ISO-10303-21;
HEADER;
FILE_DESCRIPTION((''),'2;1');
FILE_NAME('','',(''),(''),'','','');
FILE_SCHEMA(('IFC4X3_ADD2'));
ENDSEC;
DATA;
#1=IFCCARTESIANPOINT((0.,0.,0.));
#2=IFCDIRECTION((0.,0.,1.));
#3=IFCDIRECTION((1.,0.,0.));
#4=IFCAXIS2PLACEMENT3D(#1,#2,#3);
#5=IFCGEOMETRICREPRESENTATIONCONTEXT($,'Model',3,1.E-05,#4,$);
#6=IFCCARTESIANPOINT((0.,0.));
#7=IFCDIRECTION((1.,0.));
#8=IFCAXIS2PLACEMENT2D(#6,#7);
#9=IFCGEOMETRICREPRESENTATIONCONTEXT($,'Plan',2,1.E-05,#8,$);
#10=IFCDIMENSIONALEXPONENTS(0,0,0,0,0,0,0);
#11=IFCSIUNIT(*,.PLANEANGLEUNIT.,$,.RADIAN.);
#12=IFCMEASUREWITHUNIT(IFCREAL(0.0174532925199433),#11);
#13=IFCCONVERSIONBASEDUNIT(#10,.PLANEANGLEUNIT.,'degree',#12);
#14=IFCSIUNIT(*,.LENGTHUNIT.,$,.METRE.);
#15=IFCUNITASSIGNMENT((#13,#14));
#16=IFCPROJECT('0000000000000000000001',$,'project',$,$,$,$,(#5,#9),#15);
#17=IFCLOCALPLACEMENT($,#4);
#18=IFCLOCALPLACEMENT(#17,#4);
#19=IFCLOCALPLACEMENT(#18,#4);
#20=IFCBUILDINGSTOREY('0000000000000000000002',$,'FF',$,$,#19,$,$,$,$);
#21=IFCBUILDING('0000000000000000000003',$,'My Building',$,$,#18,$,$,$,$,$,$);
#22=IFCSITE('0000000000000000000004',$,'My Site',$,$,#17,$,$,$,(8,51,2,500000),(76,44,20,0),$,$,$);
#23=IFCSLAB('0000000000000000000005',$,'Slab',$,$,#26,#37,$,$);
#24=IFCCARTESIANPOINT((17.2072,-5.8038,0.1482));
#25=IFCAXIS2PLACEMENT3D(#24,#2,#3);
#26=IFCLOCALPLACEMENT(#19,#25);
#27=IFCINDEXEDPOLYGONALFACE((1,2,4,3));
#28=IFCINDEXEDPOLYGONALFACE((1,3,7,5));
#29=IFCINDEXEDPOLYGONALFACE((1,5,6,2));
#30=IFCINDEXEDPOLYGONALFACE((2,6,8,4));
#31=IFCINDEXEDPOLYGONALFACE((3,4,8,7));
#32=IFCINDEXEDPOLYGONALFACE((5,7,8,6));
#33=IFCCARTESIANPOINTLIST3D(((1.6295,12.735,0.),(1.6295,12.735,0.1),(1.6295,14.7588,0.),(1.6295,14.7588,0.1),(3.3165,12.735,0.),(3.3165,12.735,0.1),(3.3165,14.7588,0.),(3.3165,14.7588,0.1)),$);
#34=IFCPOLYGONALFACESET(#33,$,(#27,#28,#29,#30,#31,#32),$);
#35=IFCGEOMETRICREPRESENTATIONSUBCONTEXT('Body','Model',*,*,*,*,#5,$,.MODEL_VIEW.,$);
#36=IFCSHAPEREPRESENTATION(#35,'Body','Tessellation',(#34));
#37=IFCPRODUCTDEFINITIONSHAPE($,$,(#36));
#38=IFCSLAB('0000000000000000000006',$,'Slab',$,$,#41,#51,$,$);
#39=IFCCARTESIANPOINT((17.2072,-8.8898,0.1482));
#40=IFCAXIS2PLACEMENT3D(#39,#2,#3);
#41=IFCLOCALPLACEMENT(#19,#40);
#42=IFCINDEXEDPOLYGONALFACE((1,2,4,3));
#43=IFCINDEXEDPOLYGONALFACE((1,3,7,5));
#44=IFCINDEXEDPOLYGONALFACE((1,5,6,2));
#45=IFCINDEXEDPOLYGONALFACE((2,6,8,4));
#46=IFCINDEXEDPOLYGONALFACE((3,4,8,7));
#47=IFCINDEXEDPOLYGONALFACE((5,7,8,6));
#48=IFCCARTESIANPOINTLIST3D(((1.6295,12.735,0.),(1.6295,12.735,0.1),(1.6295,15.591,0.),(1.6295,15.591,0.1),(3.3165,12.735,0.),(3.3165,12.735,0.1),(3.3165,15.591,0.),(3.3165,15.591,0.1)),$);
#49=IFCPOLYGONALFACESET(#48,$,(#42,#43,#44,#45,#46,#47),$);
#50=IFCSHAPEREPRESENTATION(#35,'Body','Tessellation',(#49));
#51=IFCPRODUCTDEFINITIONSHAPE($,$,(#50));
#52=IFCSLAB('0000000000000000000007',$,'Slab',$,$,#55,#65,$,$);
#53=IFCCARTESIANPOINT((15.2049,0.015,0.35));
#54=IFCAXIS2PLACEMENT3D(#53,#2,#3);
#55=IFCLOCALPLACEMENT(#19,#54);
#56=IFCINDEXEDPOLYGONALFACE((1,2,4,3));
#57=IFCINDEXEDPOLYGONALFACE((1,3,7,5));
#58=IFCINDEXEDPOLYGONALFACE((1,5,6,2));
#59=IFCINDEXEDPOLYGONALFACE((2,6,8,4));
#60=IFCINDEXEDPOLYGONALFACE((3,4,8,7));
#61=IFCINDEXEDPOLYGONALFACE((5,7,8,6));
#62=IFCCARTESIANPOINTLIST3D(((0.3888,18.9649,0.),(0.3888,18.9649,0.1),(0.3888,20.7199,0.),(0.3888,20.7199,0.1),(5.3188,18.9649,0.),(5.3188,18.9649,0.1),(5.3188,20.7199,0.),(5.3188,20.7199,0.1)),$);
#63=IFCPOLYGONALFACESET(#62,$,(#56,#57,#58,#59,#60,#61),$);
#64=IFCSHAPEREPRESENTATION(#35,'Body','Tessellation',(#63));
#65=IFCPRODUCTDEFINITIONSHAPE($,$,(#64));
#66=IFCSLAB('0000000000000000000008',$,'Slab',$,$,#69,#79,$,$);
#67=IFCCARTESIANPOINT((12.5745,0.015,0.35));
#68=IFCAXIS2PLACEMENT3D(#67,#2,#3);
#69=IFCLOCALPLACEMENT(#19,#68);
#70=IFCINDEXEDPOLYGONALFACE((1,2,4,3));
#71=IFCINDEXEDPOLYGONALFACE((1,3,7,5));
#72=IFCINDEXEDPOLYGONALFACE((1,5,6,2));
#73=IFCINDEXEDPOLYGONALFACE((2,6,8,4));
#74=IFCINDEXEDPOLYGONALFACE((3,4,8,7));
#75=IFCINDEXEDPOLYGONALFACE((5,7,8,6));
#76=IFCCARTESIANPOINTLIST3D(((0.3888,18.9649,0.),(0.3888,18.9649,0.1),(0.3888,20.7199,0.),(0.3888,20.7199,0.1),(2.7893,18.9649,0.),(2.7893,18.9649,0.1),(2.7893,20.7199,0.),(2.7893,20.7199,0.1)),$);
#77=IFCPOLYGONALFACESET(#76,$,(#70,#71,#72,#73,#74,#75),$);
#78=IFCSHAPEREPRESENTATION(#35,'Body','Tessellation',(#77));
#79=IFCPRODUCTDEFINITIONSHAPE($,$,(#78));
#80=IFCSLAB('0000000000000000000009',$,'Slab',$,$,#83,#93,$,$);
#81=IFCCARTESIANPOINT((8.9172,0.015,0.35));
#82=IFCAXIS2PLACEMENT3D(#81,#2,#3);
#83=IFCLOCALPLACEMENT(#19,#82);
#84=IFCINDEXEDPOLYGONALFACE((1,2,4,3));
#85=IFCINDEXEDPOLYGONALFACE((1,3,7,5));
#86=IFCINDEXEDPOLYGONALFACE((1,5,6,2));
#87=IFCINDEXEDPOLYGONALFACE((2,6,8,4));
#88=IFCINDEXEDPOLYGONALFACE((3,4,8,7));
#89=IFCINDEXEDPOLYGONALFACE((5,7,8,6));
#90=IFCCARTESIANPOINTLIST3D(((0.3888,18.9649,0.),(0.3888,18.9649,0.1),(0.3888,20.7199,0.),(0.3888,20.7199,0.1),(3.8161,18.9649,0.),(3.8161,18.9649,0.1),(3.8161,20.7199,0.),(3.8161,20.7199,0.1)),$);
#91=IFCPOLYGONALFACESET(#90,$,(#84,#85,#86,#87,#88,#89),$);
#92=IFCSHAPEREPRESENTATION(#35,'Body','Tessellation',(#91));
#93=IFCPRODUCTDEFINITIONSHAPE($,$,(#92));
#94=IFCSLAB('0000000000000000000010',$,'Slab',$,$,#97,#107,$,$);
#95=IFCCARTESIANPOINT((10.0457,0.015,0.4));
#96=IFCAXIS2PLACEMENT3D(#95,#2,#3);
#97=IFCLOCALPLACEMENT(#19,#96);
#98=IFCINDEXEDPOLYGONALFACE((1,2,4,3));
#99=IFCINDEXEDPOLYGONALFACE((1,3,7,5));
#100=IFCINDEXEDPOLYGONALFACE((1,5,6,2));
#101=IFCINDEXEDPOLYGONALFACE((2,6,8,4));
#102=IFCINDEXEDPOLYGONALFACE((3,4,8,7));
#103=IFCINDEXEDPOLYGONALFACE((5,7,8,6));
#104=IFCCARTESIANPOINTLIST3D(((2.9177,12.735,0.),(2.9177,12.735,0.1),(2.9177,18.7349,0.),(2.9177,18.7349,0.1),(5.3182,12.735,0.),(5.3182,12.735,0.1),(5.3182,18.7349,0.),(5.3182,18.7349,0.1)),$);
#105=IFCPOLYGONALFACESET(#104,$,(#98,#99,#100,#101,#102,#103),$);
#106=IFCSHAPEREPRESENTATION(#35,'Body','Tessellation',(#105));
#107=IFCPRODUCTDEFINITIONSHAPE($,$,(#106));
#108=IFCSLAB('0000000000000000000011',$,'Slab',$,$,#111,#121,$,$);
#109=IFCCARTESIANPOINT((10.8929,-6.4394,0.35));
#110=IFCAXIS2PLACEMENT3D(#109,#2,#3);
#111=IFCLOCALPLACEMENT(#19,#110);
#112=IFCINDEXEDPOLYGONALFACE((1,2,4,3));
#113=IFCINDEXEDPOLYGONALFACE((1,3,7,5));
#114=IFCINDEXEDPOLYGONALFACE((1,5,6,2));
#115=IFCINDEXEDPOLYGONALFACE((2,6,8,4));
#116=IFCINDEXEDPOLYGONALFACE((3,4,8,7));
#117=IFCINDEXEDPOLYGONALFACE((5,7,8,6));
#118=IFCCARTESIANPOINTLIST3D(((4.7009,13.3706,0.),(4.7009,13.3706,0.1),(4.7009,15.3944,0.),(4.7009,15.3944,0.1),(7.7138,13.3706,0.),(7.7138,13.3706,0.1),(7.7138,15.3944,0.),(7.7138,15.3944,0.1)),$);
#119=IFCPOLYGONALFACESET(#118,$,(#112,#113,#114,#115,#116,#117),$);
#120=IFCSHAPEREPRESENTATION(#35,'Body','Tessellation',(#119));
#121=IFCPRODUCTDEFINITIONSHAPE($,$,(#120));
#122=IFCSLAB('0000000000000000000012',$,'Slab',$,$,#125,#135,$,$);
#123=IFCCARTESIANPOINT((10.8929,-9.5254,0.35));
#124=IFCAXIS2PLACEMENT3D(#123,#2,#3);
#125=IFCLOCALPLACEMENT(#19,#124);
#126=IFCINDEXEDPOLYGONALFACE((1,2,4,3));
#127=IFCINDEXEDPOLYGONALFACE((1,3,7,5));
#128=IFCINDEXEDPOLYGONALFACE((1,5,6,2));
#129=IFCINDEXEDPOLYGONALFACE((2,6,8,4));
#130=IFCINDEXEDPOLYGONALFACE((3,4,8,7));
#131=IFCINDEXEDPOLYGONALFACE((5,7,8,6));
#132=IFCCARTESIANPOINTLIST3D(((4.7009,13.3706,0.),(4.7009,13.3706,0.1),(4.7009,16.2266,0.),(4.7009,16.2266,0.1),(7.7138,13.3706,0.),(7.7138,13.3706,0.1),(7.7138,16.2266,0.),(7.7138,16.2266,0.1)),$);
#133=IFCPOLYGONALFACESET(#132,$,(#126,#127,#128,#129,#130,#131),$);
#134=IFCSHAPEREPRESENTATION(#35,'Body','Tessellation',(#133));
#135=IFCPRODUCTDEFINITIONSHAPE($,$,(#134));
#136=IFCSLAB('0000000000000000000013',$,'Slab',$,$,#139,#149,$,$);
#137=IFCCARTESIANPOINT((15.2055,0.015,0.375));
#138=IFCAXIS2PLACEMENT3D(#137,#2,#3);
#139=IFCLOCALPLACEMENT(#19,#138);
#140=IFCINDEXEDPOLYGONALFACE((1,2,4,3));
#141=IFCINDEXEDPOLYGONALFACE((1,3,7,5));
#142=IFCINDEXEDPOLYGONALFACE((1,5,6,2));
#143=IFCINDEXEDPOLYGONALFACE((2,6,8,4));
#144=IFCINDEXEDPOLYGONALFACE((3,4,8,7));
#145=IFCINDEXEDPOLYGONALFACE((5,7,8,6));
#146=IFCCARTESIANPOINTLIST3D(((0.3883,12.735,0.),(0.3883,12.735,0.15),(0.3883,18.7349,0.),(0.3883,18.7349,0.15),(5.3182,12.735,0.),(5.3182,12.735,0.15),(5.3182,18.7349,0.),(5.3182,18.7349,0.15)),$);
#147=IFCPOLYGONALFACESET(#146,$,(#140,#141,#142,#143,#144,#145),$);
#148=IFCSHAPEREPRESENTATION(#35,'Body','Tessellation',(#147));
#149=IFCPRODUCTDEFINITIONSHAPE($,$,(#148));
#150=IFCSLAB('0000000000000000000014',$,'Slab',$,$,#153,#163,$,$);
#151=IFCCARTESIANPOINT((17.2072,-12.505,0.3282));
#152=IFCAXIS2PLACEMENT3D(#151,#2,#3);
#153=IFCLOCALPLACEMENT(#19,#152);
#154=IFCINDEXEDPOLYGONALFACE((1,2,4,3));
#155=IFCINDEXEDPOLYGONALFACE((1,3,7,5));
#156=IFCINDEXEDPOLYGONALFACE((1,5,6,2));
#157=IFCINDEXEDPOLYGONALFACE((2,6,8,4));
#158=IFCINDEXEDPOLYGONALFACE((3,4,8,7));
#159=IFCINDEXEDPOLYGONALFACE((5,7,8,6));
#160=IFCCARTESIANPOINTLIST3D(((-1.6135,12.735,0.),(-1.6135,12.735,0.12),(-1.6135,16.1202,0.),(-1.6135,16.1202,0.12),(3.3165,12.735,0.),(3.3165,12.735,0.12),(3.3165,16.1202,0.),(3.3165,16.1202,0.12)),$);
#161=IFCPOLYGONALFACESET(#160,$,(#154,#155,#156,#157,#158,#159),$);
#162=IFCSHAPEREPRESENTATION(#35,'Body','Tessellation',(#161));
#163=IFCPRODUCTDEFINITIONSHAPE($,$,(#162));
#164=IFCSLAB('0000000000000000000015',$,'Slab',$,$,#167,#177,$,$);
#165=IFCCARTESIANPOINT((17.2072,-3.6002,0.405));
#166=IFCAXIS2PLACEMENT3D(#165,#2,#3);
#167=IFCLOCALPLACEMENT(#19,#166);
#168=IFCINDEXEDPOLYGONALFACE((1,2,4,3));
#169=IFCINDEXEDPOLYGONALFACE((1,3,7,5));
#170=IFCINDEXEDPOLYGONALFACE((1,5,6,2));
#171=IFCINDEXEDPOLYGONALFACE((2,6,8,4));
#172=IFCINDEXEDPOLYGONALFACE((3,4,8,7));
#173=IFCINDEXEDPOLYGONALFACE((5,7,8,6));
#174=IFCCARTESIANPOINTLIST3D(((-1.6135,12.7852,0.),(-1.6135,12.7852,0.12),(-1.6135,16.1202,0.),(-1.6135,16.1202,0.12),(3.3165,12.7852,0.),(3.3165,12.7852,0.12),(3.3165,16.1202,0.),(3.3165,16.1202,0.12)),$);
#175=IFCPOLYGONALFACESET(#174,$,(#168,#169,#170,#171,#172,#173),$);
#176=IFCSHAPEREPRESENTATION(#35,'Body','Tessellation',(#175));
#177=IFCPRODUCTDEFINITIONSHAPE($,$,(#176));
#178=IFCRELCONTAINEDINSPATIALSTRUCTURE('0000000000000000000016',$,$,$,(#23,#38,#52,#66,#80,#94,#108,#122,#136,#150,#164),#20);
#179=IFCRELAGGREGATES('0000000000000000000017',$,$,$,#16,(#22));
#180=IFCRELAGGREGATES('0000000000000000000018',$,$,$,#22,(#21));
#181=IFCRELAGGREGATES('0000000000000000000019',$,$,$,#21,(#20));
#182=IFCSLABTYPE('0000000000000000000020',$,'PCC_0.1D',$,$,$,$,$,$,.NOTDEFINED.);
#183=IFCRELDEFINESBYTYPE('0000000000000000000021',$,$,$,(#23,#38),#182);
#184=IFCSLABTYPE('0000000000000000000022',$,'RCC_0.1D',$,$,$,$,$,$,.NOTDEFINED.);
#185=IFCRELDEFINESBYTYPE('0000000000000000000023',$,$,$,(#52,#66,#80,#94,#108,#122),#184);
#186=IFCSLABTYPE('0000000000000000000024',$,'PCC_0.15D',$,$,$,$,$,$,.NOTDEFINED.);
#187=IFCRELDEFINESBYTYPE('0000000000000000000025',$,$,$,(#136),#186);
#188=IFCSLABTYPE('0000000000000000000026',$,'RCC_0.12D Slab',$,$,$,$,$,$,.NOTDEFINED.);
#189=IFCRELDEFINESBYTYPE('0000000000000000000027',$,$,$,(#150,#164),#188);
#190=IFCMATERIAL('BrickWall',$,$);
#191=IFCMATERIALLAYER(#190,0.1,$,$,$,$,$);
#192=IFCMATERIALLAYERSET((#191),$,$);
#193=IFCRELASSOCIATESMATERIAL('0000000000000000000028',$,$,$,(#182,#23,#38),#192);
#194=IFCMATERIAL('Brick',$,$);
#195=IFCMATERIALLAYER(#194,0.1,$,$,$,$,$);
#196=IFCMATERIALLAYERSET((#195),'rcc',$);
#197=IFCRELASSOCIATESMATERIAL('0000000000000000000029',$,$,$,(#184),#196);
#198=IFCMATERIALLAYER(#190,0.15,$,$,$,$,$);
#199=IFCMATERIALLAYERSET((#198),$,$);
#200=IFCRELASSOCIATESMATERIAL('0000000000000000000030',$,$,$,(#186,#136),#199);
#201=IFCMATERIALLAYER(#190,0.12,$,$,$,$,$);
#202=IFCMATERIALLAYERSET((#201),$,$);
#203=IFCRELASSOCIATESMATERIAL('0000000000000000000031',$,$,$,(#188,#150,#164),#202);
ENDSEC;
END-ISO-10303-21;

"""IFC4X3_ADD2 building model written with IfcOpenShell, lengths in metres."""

from ifc_helpers import new_model, entity, si_unit, converted_unit, frame, origin_with_axes, origin_2d_with_axis, place, context, subcontext, project, spatial, indexed_curve, outline, extrude, material, layer, layer_set, layer_usage, type_object, element, save


model = new_model("IFC4X3_ADD2")

# Units and contexts
model_context = context("Model", 3, precision=1e-05, world=origin_with_axes())
plan_context = context("Plan", 2, precision=1e-05, world=origin_2d_with_axis())
body_context = subcontext(model_context, "Body", "Model", "MODEL_VIEW")
ifc_project = project(units=[converted_unit("PLANEANGLEUNIT", "degree", entity("IfcReal", 0.0174532925199433), si_unit("PLANEANGLEUNIT", "RADIAN"), dimensions=[0, 0, 0, 0, 0, 0, 0]), si_unit("LENGTHUNIT", "METRE")], contexts=[model_context, plan_context])

# Site, building, storey
site_placement = place(None, origin_with_axes())
site = spatial("IfcSite", under=ifc_project, at=site_placement, Name="My Site", RefLatitude=(8, 51, 2, 500000), RefLongitude=(76, 44, 20, 0))
building_placement = place(site_placement, origin_with_axes())
building = spatial("IfcBuilding", under=site, at=building_placement, Name="My Building")
storey_placement = place(building_placement, origin_with_axes())
storey = spatial("IfcBuildingStorey", under=building, at=storey_placement, Name="FF")

# Shared definitions
ifc_material_1 = material(Name="Brick")

# Slabs
ifc_material_2 = material(Name="BrickWall")
ifc_layer_1 = layer(ifc_material_2, 0.1)
ifc_layer_set_1 = layer_set([ifc_layer_1])
ifc_layer_usage_1 = layer_usage(ifc_layer_set_1, "AXIS3", "POSITIVE", 0.0)
slab_type_1 = type_object("IfcSlabType", Name="PCC_0.1D", PredefinedType="NOTDEFINED", material=ifc_layer_set_1)
slab_1_placement = place(storey_placement, frame((17.2072, -5.8038, 0.1482), z_axis=(0.0, 0.0, 1.0), x_axis=(1.0, 0.0, 0.0)))
element("IfcSlab", 1, at=slab_1_placement, inside=storey, type_object=slab_type_1, material=ifc_layer_usage_1, Name="Slab", context=body_context, shape_type="SweptSolid", body=[
    extrude(outline(indexed_curve([(1.6295, 14.7588), (1.6295, 12.735), (3.3165, 12.735), (3.3165, 14.7588), (1.6295, 14.7588)])), None, (0.0, 0.0, 1.0), 0.1),
])
ifc_layer_usage_2 = layer_usage(ifc_layer_set_1, "AXIS3", "POSITIVE", 0.0)
slab_2_placement = place(storey_placement, frame((17.2072, -8.8898, 0.1482), z_axis=(0.0, 0.0, 1.0), x_axis=(1.0, 0.0, 0.0)))
element("IfcSlab", 2, at=slab_2_placement, inside=storey, type_object=slab_type_1, material=ifc_layer_usage_2, Name="Slab", context=body_context, shape_type="SweptSolid", body=[
    extrude(outline(indexed_curve([(3.3165, 15.591), (3.3165, 12.735), (1.6295, 12.735), (1.6295, 15.591), (3.3165, 15.591)])), None, (0.0, 0.0, 1.0), 0.1),
])
ifc_layer_2 = layer(ifc_material_1, 0.1)
ifc_layer_set_2 = layer_set([ifc_layer_2], Name="rcc")
slab_type_2 = type_object("IfcSlabType", Name="RCC_0.1D", PredefinedType="NOTDEFINED", material=ifc_layer_set_2)
slab_3_placement = place(storey_placement, frame((15.2049, 0.015, 0.35), z_axis=(0.0, 0.0, 1.0), x_axis=(1.0, 0.0, 0.0)))
element("IfcSlab", 3, at=slab_3_placement, inside=storey, type_object=slab_type_2, Name="Slab", context=body_context, shape_type="SweptSolid", body=[
    extrude(outline(indexed_curve([(5.3188, 18.9649), (5.3188, 20.7199), (0.3888, 20.7199), (0.3888, 18.9649), (5.3188, 18.9649)])), None, (0.0, 0.0, 1.0), 0.1),
])
slab_4_placement = place(storey_placement, frame((12.5745, 0.015, 0.35), z_axis=(0.0, 0.0, 1.0), x_axis=(1.0, 0.0, 0.0)))
element("IfcSlab", 4, at=slab_4_placement, inside=storey, type_object=slab_type_2, Name="Slab", context=body_context, shape_type="SweptSolid", body=[
    extrude(outline(indexed_curve([(0.3888, 18.9649), (0.3888, 20.7199), (2.7893, 20.7199), (2.7893, 18.9649), (0.3888, 18.9649)])), None, (0.0, 0.0, 1.0), 0.1),
])
slab_5_placement = place(storey_placement, frame((8.9172, 0.015, 0.35), z_axis=(0.0, 0.0, 1.0), x_axis=(1.0, 0.0, 0.0)))
element("IfcSlab", 5, at=slab_5_placement, inside=storey, type_object=slab_type_2, Name="Slab", context=body_context, shape_type="SweptSolid", body=[
    extrude(outline(indexed_curve([(3.8161, 18.9649), (3.8161, 20.7199), (0.3888, 20.7199), (0.3888, 18.9649), (3.8161, 18.9649)])), None, (0.0, 0.0, 1.0), 0.1),
])
slab_6_placement = place(storey_placement, frame((10.0457, 0.015, 0.4), z_axis=(0.0, 0.0, 1.0), x_axis=(1.0, 0.0, 0.0)))
element("IfcSlab", 6, at=slab_6_placement, inside=storey, type_object=slab_type_2, Name="Slab", context=body_context, shape_type="SweptSolid", body=[
    extrude(outline(indexed_curve([(5.3182, 18.7349), (5.3182, 12.735), (2.9177, 12.735), (2.9177, 18.7349), (5.3182, 18.7349)])), None, (0.0, 0.0, 1.0), 0.1),
])
slab_7_placement = place(storey_placement, frame((10.8929, -6.4394, 0.35), z_axis=(0.0, 0.0, 1.0), x_axis=(1.0, 0.0, 0.0)))
element("IfcSlab", 7, at=slab_7_placement, inside=storey, type_object=slab_type_2, Name="Slab", context=body_context, shape_type="SweptSolid", body=[
    extrude(outline(indexed_curve([(7.7138, 15.3944), (7.7138, 13.3706), (4.7009, 13.3706), (4.7009, 15.3944), (7.7138, 15.3944)])), None, (0.0, 0.0, 1.0), 0.1),
])
slab_8_placement = place(storey_placement, frame((10.8929, -9.5254, 0.35), z_axis=(0.0, 0.0, 1.0), x_axis=(1.0, 0.0, 0.0)))
element("IfcSlab", 8, at=slab_8_placement, inside=storey, type_object=slab_type_2, Name="Slab", context=body_context, shape_type="SweptSolid", body=[
    extrude(outline(indexed_curve([(4.7009, 16.2266), (4.7009, 13.3706), (7.7138, 13.3706), (7.7138, 16.2266), (4.7009, 16.2266)])), None, (0.0, 0.0, 1.0), 0.1),
])
ifc_layer_3 = layer(ifc_material_2, 0.15)
ifc_layer_set_3 = layer_set([ifc_layer_3])
ifc_layer_usage_3 = layer_usage(ifc_layer_set_3, "AXIS3", "POSITIVE", 0.0)
slab_type_3 = type_object("IfcSlabType", Name="PCC_0.15D", PredefinedType="NOTDEFINED", material=ifc_layer_set_3)
slab_9_placement = place(storey_placement, frame((15.2055, 0.015, 0.375), z_axis=(0.0, 0.0, 1.0), x_axis=(1.0, 0.0, 0.0)))
element("IfcSlab", 9, at=slab_9_placement, inside=storey, type_object=slab_type_3, material=ifc_layer_usage_3, Name="Slab", context=body_context, shape_type="SweptSolid", body=[
    extrude(outline(indexed_curve([(5.3182, 18.7349), (5.3182, 12.735), (0.3883, 12.735), (0.3883, 18.7349), (5.3182, 18.7349)])), None, (0.0, 0.0, 1.0), 0.15),
])
ifc_layer_4 = layer(ifc_material_2, 0.12)
ifc_layer_set_4 = layer_set([ifc_layer_4])
ifc_layer_usage_4 = layer_usage(ifc_layer_set_4, "AXIS3", "POSITIVE", 0.0)
slab_type_4 = type_object("IfcSlabType", Name="RCC_0.12D Slab", PredefinedType="NOTDEFINED", material=ifc_layer_set_4)
slab_10_placement = place(storey_placement, frame((17.2072, -12.505, 0.3282), z_axis=(0.0, 0.0, 1.0), x_axis=(1.0, 0.0, 0.0)))
element("IfcSlab", 10, at=slab_10_placement, inside=storey, type_object=slab_type_4, material=ifc_layer_usage_4, Name="Slab", context=body_context, shape_type="SweptSolid", body=[
    extrude(outline(indexed_curve([(-1.6135, 16.1202), (-1.6135, 12.735), (3.3165, 12.735), (3.3165, 16.1202), (-1.6135, 16.1202)])), origin_with_axes(), (0.0, 0.0, 1.0), 0.12),
])
ifc_layer_usage_5 = layer_usage(ifc_layer_set_4, "AXIS3", "POSITIVE", 0.0)
slab_11_placement = place(storey_placement, frame((17.2072, -3.6002, 0.405), z_axis=(0.0, 0.0, 1.0), x_axis=(1.0, 0.0, 0.0)))
element("IfcSlab", 11, at=slab_11_placement, inside=storey, type_object=slab_type_4, material=ifc_layer_usage_5, Name="Slab", context=body_context, shape_type="SweptSolid", body=[
    extrude(outline(indexed_curve([(3.3165, 16.1202), (3.3165, 12.7852), (-1.6135, 12.7852), (-1.6135, 16.1202), (3.3165, 16.1202)])), origin_with_axes(), (0.0, 0.0, 1.0), 0.12),
])

save(model, "model.ifc")
